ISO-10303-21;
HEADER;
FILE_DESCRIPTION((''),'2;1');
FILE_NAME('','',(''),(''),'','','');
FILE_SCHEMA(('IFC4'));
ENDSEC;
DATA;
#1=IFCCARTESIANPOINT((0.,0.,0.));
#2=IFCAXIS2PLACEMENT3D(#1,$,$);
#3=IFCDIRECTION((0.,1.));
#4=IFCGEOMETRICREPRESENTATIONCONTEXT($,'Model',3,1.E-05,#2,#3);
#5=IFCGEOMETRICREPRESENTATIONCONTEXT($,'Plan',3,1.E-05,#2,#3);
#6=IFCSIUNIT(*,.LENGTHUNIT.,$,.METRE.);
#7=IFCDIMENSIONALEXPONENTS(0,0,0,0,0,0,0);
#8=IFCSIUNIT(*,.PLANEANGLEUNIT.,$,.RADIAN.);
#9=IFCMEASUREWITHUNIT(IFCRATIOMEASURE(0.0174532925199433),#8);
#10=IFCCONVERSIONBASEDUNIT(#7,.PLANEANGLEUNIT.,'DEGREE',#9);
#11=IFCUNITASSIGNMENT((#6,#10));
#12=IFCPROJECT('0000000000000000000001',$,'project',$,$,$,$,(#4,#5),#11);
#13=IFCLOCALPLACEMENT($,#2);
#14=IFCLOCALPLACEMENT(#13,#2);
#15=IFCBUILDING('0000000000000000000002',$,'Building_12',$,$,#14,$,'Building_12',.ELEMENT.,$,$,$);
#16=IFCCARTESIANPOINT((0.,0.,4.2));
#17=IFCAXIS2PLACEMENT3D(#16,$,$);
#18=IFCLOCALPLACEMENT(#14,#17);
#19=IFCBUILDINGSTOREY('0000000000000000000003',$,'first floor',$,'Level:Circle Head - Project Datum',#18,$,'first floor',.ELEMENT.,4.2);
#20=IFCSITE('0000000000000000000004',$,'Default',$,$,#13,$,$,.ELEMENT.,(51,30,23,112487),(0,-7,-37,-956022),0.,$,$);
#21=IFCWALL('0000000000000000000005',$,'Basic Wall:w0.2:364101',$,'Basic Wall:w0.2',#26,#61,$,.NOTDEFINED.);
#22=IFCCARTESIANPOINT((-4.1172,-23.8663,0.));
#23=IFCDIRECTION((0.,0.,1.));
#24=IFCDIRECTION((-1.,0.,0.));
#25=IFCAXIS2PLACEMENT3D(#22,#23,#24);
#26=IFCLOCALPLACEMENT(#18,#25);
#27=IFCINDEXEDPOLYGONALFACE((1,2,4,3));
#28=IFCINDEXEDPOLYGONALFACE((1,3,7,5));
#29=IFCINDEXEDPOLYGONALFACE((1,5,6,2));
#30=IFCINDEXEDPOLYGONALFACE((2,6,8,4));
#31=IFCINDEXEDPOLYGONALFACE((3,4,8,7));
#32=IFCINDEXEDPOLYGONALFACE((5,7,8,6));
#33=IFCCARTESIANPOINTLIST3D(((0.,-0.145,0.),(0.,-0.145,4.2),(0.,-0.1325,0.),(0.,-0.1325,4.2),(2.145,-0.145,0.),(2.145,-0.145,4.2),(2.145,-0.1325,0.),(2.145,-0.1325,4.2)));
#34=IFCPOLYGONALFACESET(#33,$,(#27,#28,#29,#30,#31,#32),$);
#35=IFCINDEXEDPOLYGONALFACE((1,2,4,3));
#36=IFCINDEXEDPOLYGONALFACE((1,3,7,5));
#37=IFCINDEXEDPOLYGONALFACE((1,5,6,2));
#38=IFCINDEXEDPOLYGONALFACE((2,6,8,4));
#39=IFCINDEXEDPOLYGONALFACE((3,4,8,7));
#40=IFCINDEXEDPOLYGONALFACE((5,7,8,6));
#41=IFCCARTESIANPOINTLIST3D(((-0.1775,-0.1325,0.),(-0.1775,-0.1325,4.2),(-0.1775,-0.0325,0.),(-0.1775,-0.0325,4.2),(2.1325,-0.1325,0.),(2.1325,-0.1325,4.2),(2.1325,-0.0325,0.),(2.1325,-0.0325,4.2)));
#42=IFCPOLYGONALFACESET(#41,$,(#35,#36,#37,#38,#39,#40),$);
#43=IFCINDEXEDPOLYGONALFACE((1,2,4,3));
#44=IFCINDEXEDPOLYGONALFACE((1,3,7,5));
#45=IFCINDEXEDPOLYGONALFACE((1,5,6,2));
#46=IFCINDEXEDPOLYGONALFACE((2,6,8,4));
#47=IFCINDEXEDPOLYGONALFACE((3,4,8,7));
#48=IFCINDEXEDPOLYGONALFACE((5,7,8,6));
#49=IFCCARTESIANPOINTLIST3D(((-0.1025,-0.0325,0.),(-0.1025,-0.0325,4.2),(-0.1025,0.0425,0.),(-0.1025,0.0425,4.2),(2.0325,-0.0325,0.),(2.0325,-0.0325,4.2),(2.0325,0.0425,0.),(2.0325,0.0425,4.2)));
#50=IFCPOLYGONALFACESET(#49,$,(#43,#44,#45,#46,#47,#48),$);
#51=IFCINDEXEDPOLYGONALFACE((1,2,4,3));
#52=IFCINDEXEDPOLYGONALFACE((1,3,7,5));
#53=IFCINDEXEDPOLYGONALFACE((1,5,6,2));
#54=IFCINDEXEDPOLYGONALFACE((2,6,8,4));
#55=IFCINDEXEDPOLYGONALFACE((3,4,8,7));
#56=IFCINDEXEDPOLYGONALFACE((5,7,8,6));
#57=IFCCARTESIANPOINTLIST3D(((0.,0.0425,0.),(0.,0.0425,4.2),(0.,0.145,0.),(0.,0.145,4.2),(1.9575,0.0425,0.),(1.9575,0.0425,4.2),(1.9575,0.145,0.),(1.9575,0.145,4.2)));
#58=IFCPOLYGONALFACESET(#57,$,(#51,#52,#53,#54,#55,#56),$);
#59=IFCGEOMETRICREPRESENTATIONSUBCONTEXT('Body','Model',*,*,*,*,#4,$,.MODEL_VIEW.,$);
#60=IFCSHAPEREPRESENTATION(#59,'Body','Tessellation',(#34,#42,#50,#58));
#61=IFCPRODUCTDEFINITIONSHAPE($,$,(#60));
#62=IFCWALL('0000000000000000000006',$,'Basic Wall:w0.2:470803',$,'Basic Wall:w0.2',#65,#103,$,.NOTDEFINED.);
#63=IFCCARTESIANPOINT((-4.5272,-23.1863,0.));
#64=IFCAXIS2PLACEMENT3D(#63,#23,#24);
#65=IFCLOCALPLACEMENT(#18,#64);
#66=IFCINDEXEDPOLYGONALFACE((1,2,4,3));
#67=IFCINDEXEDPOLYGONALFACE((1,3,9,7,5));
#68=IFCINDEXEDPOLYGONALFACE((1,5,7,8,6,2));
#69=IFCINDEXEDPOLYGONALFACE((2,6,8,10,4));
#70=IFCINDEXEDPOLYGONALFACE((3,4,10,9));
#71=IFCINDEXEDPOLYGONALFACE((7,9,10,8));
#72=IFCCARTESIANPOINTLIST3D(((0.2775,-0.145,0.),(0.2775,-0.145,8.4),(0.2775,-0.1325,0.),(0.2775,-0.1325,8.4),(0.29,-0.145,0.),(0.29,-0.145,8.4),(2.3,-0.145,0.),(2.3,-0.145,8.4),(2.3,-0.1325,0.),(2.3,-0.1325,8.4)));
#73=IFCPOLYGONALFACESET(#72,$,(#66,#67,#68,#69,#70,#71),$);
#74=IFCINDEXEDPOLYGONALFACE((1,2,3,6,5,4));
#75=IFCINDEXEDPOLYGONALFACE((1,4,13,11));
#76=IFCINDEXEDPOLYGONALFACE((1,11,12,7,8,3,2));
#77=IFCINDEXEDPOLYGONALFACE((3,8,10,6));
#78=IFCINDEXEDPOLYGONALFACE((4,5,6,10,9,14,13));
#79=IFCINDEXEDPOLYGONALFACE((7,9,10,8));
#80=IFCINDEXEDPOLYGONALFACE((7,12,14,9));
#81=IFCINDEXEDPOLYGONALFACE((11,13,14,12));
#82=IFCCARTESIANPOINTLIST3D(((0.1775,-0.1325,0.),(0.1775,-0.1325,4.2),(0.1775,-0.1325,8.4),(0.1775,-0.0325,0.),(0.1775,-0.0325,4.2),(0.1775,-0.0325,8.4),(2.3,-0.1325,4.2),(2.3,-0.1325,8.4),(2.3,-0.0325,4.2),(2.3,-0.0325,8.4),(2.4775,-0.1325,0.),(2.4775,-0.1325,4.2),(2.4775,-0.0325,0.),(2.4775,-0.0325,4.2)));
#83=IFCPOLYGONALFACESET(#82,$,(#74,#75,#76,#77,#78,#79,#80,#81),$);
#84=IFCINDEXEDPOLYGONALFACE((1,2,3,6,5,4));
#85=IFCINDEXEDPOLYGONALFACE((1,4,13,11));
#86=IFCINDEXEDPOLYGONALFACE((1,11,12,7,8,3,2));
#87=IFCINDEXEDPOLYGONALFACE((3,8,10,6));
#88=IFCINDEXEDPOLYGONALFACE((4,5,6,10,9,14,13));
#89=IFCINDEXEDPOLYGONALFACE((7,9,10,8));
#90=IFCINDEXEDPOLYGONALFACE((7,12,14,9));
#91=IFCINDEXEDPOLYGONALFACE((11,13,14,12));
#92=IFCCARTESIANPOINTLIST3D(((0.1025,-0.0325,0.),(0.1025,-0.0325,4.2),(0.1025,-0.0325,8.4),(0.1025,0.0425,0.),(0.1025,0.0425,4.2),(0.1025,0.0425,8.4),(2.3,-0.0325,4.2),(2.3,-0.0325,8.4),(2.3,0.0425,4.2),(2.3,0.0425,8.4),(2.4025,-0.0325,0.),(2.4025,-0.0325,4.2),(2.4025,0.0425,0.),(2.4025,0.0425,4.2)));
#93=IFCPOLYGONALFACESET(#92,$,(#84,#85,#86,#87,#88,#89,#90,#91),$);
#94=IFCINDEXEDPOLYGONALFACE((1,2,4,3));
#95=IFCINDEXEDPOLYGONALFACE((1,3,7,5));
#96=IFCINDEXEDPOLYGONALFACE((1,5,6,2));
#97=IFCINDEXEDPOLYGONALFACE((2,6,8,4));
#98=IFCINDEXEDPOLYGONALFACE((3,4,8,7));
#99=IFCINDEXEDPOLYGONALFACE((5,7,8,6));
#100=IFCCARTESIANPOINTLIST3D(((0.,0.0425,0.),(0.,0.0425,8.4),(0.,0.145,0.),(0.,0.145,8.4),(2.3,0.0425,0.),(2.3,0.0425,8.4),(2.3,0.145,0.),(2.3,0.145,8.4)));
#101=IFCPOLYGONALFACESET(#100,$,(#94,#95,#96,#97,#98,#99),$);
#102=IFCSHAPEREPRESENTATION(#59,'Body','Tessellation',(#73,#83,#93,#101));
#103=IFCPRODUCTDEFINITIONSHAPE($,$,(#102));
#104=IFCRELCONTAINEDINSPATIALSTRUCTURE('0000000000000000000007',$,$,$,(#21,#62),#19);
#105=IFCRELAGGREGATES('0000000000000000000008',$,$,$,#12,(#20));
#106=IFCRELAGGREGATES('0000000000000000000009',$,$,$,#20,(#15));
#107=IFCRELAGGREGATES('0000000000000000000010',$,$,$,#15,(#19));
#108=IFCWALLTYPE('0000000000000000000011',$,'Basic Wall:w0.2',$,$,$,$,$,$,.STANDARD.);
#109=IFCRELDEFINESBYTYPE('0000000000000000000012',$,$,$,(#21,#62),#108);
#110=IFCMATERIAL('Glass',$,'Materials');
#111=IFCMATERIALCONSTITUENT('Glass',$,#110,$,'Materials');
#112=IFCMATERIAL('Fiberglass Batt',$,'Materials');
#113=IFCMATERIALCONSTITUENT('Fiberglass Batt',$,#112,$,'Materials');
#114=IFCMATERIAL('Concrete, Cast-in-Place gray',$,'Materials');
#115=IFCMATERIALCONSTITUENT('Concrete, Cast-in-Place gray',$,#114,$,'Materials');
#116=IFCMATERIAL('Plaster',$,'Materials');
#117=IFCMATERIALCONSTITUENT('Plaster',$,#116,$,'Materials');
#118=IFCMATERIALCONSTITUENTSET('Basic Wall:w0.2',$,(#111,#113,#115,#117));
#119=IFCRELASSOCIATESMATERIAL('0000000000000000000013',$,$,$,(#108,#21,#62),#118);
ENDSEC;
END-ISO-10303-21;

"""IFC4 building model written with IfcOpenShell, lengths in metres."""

from ifc_helpers import new_model, entity, si_unit, converted_unit, direction, frame, origin, place, context, subcontext, project, spatial, indexed_curve, outline, extrude, material, constituent, constituent_set, type_object, element, save


model = new_model("IFC4")

# Units and contexts
model_context = context("Model", 3, precision=1e-05, world=origin(), true_north=direction((0.0, 1.0)))
plan_context = context("Plan", 3, precision=1e-05, world=origin(), true_north=direction((0.0, 1.0)))
body_context = subcontext(model_context, "Body", "Model", "MODEL_VIEW")
ifc_project = project(units=[si_unit("LENGTHUNIT", "METRE"), converted_unit("PLANEANGLEUNIT", "DEGREE", entity("IfcRatioMeasure", 0.0174532925199433), si_unit("PLANEANGLEUNIT", "RADIAN"), dimensions=[0, 0, 0, 0, 0, 0, 0])], contexts=[model_context, plan_context])

# Site, building, storey
site_placement = place(None, origin())
site = spatial("IfcSite", under=ifc_project, at=site_placement, Name="Default", CompositionType="ELEMENT", RefLatitude=(51, 30, 23, 112487), RefLongitude=(0, -7, -37, -956022), RefElevation=0.0)
building_placement = place(site_placement, origin())
building = spatial("IfcBuilding", under=site, at=building_placement, Name="Building_12", LongName="Building_12", CompositionType="ELEMENT")
storey_placement = place(building_placement, frame((0.0, 0.0, 4.2)))
storey = spatial("IfcBuildingStorey", under=building, at=storey_placement, Name="first floor", ObjectType="Level:Circle Head - Project Datum", LongName="first floor", CompositionType="ELEMENT", Elevation=4.2)

# Wall, opening
ifc_material_1 = material(Name="Glass", Category="Materials")
ifc_constituent_1 = constituent(ifc_material_1, Name="Glass", Category="Materials")
ifc_material_2 = material(Name="Fiberglass Batt", Category="Materials")
ifc_constituent_2 = constituent(ifc_material_2, Name="Fiberglass Batt", Category="Materials")
ifc_material_3 = material(Name="Concrete, Cast-in-Place gray", Category="Materials")
ifc_constituent_3 = constituent(ifc_material_3, Name="Concrete, Cast-in-Place gray", Category="Materials")
ifc_material_4 = material(Name="Plaster", Category="Materials")
ifc_constituent_4 = constituent(ifc_material_4, Name="Plaster", Category="Materials")
ifc_constituent_set_1 = constituent_set(constituents=[ifc_constituent_1, ifc_constituent_2, ifc_constituent_3, ifc_constituent_4], Name="Basic Wall:w0.2")
wall_type_1 = type_object("IfcWallType", Name="Basic Wall:w0.2", PredefinedType="STANDARD", material=ifc_constituent_set_1)
wall_1_placement = place(storey_placement, frame((-4.1172, -23.8663, 0.0), z_axis=(0.0, 0.0, 1.0), x_axis=(-1.0, 0.0, 0.0)))
wall_1 = element("IfcWall", 1, at=wall_1_placement, inside=storey, type_object=wall_type_1, material=ifc_constituent_set_1, Name="Basic Wall:w0.2:364101", ObjectType="Basic Wall:w0.2", PredefinedType="NOTDEFINED", context=body_context, shape_type="SweptSolid", body=[
    extrude(outline(indexed_curve([(-0.734, -0.005), (1.256, -0.005), (1.256, 0.0075), (-0.889, 0.0075), (-0.889, -0.005), (-0.734, -0.005)], self_intersect=False)), frame((0.889, -0.14, 0.0)), (0.0, 0.0, 1.0), 4.2),
    extrude(outline(indexed_curve([(-1.155, -0.05), (1.155, -0.05), (1.155, 0.05), (-1.155, 0.05), (-1.155, -0.05)], self_intersect=False)), frame((0.9775, -0.0825, 0.0)), (0.0, 0.0, 1.0), 4.2),
    extrude(outline(indexed_curve([(-1.0675, -0.0375), (1.0675, -0.0375), (1.0675, 0.0375), (-1.0675, 0.0375), (-1.0675, -0.0375)], self_intersect=False)), frame((0.965, 0.005, 0.0)), (0.0, 0.0, 1.0), 4.2),
    extrude(outline(indexed_curve([(-0.0513, -0.9788), (0.0512, -0.9788), (0.0513, 0.9788), (-0.0512, 0.9788), (-0.0513, -0.9788)], self_intersect=False)), frame((0.9788, 0.0938, 0.0), z_axis=(0.0, 0.0, 1.0), x_axis=(0.0, -1.0, 0.0)), (0.0, 0.0, 1.0), 4.2),
])
opening_1_placement = place(wall_1_placement, origin())
element("IfcOpeningElement", 2, at=opening_1_placement, cuts=wall_1, PredefinedType="OPENING", context=body_context, shape_type="SweptSolid", body=[
    extrude(outline(indexed_curve([(-0.145, -1.055), (0.145, -1.055), (0.145, 1.055), (-0.145, 1.055), (-0.145, -1.055)], self_intersect=False)), frame((2.0, 0.145, 1.055), z_axis=(0.0, 1.0, 0.0), x_axis=(-1.0, 0.0, 0.0)), (0.0, 0.0, 1.0), 0.81),
])

# Wall
wall_2_placement = place(storey_placement, frame((-4.5272, -23.1863, 0.0), z_axis=(0.0, 0.0, 1.0), x_axis=(-1.0, 0.0, 0.0)))
element("IfcWall", 3, at=wall_2_placement, inside=storey, type_object=wall_type_1, material=ifc_constituent_set_1, Name="Basic Wall:w0.2:470803", ObjectType="Basic Wall:w0.2", PredefinedType="NOTDEFINED", context=body_context, shape_type="SweptSolid", body=[
    extrude(outline(indexed_curve([(-0.799, -0.005), (1.211, -0.005), (1.211, 0.0075), (-0.8115, 0.0075), (-0.8115, -0.005), (-0.799, -0.005)], self_intersect=False)), frame((1.089, -0.14, 0.0)), (0.0, 0.0, 1.0), 8.4),
    extrude(outline(indexed_curve([(-4.2, -1.0364), (0.0, -1.0364), (0.0, -0.8589), (4.2, -0.8589), (4.2, 1.2636), (0.0, 1.2636), (-4.2, 1.2636), (-4.2, -1.0364)], self_intersect=False)), frame((1.4411, -0.0325, 4.2), z_axis=(0.0, -1.0, 0.0), x_axis=(0.0, 0.0, 1.0)), (0.0, 0.0, 1.0), 0.1),
    extrude(outline(indexed_curve([(-4.2, -1.015), (0.0, -1.015), (0.0, -0.9125), (4.2, -0.9125), (4.2, 1.285), (0.0, 1.285), (-4.2, 1.285), (-4.2, -1.015)], self_intersect=False)), frame((1.3875, 0.0425, 4.2), z_axis=(0.0, -1.0, 0.0), x_axis=(0.0, 0.0, 1.0)), (0.0, 0.0, 1.0), 0.075),
    extrude(outline(indexed_curve([(-0.0513, -1.15), (0.0512, -1.15), (0.0513, 1.15), (-0.0512, 1.15), (-0.0513, -1.15)], self_intersect=False)), frame((1.15, 0.0938, 0.0), z_axis=(0.0, 0.0, 1.0), x_axis=(0.0, 1.0, 0.0)), (0.0, 0.0, 1.0), 8.4),
])

save(model, "model.ifc")
